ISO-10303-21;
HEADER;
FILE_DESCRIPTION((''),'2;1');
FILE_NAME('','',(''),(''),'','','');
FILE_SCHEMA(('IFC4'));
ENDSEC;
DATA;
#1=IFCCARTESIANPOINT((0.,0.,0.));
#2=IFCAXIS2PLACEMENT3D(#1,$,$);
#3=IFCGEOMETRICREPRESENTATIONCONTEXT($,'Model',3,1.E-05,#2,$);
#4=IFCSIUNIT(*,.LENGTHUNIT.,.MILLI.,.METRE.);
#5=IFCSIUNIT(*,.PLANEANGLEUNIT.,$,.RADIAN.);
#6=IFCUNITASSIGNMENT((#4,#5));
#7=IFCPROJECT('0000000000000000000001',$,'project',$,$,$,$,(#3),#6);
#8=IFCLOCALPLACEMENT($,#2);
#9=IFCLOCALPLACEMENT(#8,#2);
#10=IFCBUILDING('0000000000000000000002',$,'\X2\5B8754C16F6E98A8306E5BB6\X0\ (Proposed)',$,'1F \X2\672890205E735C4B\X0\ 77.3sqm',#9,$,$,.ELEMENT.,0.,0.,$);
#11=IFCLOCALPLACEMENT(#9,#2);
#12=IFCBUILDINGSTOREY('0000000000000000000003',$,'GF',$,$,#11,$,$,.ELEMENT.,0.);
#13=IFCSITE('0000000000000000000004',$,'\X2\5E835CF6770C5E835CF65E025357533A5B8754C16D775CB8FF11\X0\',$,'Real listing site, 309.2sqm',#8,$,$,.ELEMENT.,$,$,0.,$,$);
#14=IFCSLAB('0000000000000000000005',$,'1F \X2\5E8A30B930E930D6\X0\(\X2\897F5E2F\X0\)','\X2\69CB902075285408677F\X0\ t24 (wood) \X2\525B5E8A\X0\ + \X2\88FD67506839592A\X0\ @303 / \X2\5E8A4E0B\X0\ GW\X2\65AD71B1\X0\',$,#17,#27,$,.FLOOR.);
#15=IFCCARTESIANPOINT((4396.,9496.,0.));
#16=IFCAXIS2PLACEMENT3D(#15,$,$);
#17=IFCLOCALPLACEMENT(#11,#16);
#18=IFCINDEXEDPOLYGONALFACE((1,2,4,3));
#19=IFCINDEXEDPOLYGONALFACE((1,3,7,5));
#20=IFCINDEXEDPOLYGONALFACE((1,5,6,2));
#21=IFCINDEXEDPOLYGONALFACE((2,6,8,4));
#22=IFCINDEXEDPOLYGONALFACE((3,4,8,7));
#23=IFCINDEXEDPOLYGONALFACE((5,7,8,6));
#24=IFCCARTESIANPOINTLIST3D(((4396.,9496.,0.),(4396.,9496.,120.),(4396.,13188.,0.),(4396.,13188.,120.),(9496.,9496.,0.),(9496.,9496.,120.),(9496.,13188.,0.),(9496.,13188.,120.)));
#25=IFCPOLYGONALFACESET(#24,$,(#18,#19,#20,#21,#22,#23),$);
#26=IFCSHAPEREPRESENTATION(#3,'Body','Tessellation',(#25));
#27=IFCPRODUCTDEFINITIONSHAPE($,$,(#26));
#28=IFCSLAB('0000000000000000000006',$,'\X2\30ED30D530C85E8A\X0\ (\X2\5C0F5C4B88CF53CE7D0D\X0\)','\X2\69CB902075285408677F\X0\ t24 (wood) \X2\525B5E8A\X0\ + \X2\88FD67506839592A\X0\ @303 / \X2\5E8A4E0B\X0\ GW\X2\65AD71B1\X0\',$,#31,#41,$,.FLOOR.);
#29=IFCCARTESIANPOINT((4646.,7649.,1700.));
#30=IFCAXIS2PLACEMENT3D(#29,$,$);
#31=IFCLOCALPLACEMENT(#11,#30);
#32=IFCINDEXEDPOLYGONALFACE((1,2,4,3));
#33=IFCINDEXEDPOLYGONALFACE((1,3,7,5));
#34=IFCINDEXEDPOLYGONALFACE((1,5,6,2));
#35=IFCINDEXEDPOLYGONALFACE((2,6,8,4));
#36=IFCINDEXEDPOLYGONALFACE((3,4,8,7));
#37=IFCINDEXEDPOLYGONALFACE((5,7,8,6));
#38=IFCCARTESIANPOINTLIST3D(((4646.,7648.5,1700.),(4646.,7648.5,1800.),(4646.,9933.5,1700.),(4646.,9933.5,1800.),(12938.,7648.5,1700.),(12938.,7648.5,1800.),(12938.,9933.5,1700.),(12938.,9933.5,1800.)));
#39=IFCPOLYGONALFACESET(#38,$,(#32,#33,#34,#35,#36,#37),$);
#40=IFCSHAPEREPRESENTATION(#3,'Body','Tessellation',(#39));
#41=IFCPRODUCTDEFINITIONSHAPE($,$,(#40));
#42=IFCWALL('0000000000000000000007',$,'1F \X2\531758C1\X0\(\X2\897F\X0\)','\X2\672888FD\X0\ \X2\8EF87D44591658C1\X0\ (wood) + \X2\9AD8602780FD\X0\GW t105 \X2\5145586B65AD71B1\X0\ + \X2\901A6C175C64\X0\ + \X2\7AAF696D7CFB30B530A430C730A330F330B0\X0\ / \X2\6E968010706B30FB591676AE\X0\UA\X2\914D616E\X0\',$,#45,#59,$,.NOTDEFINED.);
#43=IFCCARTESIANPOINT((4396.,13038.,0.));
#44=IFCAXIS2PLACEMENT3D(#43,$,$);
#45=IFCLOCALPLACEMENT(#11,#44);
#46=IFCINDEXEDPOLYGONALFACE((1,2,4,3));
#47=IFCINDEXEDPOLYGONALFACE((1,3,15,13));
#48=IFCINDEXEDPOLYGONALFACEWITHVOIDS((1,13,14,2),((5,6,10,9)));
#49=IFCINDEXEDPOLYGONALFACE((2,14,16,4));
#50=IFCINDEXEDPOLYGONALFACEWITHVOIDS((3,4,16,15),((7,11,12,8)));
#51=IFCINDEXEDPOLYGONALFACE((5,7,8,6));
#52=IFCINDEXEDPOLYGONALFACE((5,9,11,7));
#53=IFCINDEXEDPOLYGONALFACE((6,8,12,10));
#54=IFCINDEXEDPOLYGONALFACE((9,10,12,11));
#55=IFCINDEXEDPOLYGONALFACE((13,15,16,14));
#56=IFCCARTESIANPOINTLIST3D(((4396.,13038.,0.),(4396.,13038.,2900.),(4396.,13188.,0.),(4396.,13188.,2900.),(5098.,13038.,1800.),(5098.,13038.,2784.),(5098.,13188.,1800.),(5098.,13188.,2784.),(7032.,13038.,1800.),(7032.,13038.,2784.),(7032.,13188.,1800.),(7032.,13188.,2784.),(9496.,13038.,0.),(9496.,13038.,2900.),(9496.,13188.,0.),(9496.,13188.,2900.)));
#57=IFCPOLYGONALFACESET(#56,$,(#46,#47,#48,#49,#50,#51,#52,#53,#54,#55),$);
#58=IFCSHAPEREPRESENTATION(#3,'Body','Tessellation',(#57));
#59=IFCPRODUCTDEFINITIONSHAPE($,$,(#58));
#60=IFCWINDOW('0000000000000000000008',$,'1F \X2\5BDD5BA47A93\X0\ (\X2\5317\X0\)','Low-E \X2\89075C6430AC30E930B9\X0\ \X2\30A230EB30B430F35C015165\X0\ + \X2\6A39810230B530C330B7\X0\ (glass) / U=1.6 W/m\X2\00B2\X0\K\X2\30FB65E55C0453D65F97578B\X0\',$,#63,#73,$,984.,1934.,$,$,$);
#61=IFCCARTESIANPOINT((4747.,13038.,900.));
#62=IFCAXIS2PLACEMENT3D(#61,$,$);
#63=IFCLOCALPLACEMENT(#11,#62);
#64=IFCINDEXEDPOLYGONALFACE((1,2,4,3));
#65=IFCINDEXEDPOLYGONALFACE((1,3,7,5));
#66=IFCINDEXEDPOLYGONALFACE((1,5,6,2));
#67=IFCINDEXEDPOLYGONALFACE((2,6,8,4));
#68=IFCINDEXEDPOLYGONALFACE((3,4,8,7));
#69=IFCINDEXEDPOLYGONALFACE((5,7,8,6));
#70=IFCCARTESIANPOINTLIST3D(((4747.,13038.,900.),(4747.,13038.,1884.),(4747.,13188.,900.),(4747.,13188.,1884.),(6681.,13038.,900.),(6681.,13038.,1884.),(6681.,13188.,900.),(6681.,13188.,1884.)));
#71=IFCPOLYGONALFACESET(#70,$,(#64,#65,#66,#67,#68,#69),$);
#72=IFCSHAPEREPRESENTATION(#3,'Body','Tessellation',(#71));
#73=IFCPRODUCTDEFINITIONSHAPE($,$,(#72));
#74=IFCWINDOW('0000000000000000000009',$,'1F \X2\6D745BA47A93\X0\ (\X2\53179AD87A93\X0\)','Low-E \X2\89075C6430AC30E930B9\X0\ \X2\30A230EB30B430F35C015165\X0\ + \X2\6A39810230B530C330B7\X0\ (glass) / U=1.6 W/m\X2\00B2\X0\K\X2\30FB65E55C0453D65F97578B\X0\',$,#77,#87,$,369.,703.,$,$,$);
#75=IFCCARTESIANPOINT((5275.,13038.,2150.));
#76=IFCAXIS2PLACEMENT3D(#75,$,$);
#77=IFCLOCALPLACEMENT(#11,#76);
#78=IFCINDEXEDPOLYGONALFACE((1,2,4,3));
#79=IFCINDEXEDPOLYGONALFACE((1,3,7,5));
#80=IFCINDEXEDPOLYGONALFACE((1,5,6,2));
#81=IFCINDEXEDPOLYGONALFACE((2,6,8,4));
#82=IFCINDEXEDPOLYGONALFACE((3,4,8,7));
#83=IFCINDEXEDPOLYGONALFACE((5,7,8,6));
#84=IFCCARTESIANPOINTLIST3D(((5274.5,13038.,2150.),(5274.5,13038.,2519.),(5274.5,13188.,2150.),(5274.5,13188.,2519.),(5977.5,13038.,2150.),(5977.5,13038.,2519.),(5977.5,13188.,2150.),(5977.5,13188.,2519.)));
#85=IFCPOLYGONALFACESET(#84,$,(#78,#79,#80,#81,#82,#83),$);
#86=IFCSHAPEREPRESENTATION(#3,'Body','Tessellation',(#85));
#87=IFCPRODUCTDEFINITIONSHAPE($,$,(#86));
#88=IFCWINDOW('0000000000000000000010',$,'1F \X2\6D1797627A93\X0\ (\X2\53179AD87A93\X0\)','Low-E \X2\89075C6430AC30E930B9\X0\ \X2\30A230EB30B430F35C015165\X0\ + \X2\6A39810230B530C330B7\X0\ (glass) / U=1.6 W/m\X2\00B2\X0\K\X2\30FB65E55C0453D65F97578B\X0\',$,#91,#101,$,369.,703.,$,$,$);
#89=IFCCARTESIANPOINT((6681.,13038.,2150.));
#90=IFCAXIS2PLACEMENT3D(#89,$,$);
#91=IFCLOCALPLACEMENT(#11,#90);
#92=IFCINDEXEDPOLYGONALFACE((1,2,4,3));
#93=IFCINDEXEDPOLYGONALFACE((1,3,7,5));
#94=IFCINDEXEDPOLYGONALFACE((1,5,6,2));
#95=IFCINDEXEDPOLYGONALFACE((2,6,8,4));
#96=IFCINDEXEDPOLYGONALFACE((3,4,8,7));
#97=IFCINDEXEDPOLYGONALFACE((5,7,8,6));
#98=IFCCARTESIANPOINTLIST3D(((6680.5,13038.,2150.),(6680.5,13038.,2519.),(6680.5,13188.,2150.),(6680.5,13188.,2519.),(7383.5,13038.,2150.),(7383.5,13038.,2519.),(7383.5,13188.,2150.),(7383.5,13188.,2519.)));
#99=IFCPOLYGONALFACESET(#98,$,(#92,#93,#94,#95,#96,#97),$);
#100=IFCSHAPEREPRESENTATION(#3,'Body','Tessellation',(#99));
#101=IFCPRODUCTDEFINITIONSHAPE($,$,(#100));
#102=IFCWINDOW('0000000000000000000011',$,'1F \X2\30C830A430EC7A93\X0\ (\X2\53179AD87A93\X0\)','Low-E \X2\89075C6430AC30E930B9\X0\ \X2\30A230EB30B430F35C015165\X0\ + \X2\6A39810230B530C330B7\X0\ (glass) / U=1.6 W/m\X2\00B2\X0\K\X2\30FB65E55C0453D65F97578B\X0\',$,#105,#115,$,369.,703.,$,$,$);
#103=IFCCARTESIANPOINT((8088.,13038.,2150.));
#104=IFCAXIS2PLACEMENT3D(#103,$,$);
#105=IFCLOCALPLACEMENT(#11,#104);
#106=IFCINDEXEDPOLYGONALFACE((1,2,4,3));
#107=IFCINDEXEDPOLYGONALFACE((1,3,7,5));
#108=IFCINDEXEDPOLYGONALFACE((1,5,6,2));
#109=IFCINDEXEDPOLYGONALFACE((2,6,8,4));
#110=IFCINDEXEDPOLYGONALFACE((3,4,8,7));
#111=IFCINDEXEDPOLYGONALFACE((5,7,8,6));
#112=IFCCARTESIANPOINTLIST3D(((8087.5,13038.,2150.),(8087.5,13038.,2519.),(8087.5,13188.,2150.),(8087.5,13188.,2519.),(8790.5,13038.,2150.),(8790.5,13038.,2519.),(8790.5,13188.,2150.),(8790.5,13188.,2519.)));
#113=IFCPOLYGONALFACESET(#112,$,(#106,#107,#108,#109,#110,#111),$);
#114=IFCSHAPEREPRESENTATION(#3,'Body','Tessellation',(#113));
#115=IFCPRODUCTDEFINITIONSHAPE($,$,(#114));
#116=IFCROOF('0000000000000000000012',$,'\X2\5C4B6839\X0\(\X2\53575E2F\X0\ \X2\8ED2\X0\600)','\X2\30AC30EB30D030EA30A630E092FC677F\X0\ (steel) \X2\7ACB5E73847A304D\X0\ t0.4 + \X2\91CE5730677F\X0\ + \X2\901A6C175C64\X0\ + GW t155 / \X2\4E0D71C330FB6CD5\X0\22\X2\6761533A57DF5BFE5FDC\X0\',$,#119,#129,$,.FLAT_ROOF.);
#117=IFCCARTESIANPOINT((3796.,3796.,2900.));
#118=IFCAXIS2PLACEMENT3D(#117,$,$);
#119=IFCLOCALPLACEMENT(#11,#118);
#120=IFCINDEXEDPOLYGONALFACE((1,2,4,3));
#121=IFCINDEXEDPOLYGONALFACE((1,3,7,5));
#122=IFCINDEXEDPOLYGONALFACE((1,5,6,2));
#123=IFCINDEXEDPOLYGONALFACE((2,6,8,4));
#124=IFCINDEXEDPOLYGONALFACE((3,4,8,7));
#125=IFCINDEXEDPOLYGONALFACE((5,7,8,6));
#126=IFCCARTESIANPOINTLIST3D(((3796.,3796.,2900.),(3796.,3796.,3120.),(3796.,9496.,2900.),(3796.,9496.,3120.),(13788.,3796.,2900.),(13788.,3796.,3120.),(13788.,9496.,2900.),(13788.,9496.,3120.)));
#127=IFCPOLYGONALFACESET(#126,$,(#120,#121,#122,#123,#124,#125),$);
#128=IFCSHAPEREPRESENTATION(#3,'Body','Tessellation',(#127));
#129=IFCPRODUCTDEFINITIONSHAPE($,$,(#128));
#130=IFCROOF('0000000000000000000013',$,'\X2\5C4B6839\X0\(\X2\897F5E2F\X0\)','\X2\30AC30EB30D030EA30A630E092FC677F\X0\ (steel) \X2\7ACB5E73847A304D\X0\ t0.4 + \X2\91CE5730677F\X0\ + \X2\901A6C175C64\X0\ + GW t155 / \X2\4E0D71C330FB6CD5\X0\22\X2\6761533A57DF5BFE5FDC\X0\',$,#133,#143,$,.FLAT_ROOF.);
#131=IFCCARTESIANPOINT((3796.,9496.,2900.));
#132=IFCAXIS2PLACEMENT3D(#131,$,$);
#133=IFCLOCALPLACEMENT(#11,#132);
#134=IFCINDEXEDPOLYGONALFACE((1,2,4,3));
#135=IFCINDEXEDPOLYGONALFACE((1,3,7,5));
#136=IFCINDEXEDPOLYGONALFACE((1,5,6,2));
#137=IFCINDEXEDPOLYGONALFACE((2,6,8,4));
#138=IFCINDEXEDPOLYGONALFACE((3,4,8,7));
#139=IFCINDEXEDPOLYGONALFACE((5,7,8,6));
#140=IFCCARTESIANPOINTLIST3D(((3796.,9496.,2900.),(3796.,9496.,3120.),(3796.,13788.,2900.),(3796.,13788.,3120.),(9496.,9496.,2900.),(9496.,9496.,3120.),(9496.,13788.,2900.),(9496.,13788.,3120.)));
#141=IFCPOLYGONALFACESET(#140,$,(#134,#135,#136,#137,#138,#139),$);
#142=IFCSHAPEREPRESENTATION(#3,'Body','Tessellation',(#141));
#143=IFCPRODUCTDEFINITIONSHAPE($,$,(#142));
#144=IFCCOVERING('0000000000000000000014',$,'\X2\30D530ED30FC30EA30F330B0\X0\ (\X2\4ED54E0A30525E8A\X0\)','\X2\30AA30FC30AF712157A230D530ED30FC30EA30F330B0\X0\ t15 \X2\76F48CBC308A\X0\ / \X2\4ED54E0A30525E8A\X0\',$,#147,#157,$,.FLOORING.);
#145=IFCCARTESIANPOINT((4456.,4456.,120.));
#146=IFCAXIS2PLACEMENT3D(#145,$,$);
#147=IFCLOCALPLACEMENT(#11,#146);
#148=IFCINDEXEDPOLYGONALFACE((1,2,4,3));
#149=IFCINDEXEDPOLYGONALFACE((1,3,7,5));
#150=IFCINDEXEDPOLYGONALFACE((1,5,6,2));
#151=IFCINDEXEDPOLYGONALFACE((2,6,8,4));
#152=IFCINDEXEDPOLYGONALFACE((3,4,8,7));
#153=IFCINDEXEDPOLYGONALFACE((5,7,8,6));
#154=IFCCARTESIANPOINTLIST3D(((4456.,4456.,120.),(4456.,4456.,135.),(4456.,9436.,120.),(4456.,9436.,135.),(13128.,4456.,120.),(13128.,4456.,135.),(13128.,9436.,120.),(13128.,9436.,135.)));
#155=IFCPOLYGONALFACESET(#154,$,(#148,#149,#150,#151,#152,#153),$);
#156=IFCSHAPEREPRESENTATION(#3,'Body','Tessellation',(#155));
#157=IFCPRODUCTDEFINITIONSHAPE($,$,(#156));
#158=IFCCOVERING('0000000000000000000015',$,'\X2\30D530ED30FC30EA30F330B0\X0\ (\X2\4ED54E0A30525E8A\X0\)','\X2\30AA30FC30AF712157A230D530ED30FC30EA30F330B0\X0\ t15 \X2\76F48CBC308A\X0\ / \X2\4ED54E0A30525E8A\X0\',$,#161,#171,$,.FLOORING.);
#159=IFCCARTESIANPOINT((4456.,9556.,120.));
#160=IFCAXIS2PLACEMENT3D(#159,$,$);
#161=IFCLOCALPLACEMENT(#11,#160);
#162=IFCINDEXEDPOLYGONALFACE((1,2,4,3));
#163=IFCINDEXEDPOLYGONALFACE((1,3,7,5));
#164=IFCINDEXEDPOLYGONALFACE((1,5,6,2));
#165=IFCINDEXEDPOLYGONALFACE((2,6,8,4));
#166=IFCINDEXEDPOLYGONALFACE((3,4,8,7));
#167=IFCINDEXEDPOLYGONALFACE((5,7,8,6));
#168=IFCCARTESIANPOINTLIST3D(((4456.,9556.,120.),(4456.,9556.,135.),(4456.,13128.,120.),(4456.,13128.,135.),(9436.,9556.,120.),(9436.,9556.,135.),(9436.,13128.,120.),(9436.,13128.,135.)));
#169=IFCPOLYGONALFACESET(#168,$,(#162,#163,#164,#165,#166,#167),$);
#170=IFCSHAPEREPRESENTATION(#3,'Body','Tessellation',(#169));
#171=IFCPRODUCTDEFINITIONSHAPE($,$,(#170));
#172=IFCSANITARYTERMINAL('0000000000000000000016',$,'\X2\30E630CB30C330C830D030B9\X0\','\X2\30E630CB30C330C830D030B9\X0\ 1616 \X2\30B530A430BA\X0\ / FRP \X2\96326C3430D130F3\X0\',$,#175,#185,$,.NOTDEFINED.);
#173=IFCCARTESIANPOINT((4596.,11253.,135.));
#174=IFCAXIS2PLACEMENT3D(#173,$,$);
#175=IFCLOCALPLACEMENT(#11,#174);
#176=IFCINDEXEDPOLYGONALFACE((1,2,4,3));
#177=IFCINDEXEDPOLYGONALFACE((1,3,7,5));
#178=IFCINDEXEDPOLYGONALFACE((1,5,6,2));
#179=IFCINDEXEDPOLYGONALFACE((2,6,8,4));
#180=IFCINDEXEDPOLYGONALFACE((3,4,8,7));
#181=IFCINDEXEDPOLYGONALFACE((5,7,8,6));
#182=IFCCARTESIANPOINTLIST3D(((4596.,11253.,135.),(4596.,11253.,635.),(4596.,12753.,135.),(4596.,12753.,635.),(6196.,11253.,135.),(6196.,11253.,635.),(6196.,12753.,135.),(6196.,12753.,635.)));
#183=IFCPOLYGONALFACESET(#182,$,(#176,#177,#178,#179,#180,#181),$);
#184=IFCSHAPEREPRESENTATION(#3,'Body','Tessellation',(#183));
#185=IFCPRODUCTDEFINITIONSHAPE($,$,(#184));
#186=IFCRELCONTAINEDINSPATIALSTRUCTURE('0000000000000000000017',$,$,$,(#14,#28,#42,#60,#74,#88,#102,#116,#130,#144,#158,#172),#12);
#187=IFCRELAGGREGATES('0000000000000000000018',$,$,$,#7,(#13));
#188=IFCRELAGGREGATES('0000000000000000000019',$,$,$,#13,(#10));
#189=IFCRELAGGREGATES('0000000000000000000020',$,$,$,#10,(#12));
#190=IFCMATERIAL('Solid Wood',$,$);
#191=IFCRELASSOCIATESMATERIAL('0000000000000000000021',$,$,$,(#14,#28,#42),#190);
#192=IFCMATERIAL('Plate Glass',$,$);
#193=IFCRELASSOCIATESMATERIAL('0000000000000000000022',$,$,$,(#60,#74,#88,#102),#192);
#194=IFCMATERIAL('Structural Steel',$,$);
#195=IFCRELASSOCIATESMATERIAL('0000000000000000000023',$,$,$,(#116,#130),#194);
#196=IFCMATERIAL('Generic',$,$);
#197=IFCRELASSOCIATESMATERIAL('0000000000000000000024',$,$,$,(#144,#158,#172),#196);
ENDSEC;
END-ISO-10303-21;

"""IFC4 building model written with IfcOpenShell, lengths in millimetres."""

from ifc_helpers import new_model, si_unit, frame, frame_2d, origin, place, context, project, spatial, rectangle, extrude, material, element, fill, save


model = new_model("IFC4")

# Units and contexts
model_context = context("Model", 3, precision=1e-05, world=origin())
ifc_project = project(units=[si_unit("LENGTHUNIT", "METRE", prefix="MILLI"), si_unit("PLANEANGLEUNIT", "RADIAN")], contexts=[model_context])

# Site, building, storey
site_placement = place(None, origin())
site = spatial("IfcSite", under=ifc_project, at=site_placement, Name="広島県広島市南区宇品海岸１", ObjectType="Real listing site, 309.2sqm", CompositionType="ELEMENT", RefElevation=0.0)
building_placement = place(site_placement, origin())
building = spatial("IfcBuilding", under=site, at=building_placement, Name="宇品潮風の家 (Proposed)", ObjectType="1F 木造平屋 77.3sqm", CompositionType="ELEMENT", ElevationOfRefHeight=0.0, ElevationOfTerrain=0.0)
storey_placement = place(building_placement, origin())
storey = spatial("IfcBuildingStorey", under=building, at=storey_placement, Name="GF", CompositionType="ELEMENT", Elevation=0.0)

# Slabs
ifc_material_1 = material(Name="Solid Wood")
slab_1_placement = place(storey_placement, frame((4396.0, 9496.0, 0.0)))
element("IfcSlab", 1, at=slab_1_placement, inside=storey, material=ifc_material_1, Name="1F 床スラブ(西帯)", Description="構造用合板 t24 (wood) 剛床 + 製材根太 @303 / 床下 GW断熱", PredefinedType="FLOOR", context=model_context, shape_type="SweptSolid", body=[
    extrude(rectangle(XDim=5100.0, YDim=3692.0, at=frame_2d((2550.0, 1846.0))), frame((4396.0, 9496.0, 0.0)), (0.0, 0.0, 1.0), 120.0),
])
slab_2_placement = place(storey_placement, frame((4646.0, 7649.0, 1700.0)))
element("IfcSlab", 2, at=slab_2_placement, inside=storey, material=ifc_material_1, Name="ロフト床 (小屋裏収納)", Description="構造用合板 t24 (wood) 剛床 + 製材根太 @303 / 床下 GW断熱", PredefinedType="FLOOR", context=model_context, shape_type="SweptSolid", body=[
    extrude(rectangle(XDim=8292.0, YDim=2285.0, at=frame_2d((4146.0, 1142.0))), frame((4646.0, 7649.0, 1700.0)), (0.0, 0.0, 1.0), 100.0),
])

# Shared definitions
ifc_material_2 = material(Name="Plate Glass")

# Wall, openings, windows
wall_1_placement = place(storey_placement, frame((4396.0, 13038.0, 0.0)))
wall_1 = element("IfcWall", 3, at=wall_1_placement, inside=storey, material=ifc_material_1, Name="1F 北壁(西)", Description="木製 軸組外壁 (wood) + 高性能GW t105 充填断熱 + 通気層 + 窯業系サイディング / 準耐火・外皮UA配慮", PredefinedType="NOTDEFINED", context=model_context, shape_type="SweptSolid", body=[
    extrude(rectangle(XDim=5100.0, YDim=150.0, at=frame_2d((2550.0, 75.0))), frame((4396.0, 13038.0, 0.0)), (0.0, 0.0, 1.0), 2900.0),
])
opening_1_placement = place(storey_placement, frame((4747.0, 13038.0, 900.0)))
opening_1 = element("IfcOpeningElement", 4, at=opening_1_placement, cuts=wall_1, PredefinedType="NOTDEFINED", context=model_context, shape_type="SweptSolid", body=[
    extrude(rectangle(XDim=1934.0, YDim=150.0, at=frame_2d((967.0, 75.0))), frame((4747.0, 13038.0, 900.0)), (0.0, 0.0, 1.0), 984.0),
])
opening_2_placement = place(storey_placement, frame((5275.0, 13038.0, 2150.0)))
opening_2 = element("IfcOpeningElement", 5, at=opening_2_placement, cuts=wall_1, PredefinedType="NOTDEFINED", context=model_context, shape_type="SweptSolid", body=[
    extrude(rectangle(XDim=703.0, YDim=150.0, at=frame_2d((351.0, 75.0))), frame((5275.0, 13038.0, 2150.0)), (0.0, 0.0, 1.0), 369.0),
])
opening_3_placement = place(storey_placement, frame((6681.0, 13038.0, 2150.0)))
opening_3 = element("IfcOpeningElement", 6, at=opening_3_placement, cuts=wall_1, PredefinedType="NOTDEFINED", context=model_context, shape_type="SweptSolid", body=[
    extrude(rectangle(XDim=703.0, YDim=150.0, at=frame_2d((351.0, 75.0))), frame((6681.0, 13038.0, 2150.0)), (0.0, 0.0, 1.0), 369.0),
])
opening_4_placement = place(storey_placement, frame((8088.0, 13038.0, 2150.0)))
opening_4 = element("IfcOpeningElement", 7, at=opening_4_placement, cuts=wall_1, PredefinedType="NOTDEFINED", context=model_context, shape_type="SweptSolid", body=[
    extrude(rectangle(XDim=703.0, YDim=150.0, at=frame_2d((351.0, 75.0))), frame((8088.0, 13038.0, 2150.0)), (0.0, 0.0, 1.0), 369.0),
])
window_1_placement = place(storey_placement, frame((4747.0, 13038.0, 900.0)))
window_1 = element("IfcWindow", 8, at=window_1_placement, inside=storey, material=ifc_material_2, Name="1F 寝室窓 (北)", Description="Low-E 複層ガラス アルゴン封入 + 樹脂サッシ (glass) / U=1.6 W/m²K・日射取得型", OverallHeight=984.0, OverallWidth=1934.0, context=model_context, shape_type="SweptSolid", body=[
    extrude(rectangle(XDim=1934.0, YDim=150.0, at=frame_2d((967.0, 75.0))), frame((4747.0, 13038.0, 900.0)), (0.0, 0.0, 1.0), 984.0),
])
fill(opening_1, window_1)
window_2_placement = place(storey_placement, frame((5275.0, 13038.0, 2150.0)))
window_2 = element("IfcWindow", 9, at=window_2_placement, inside=storey, material=ifc_material_2, Name="1F 浴室窓 (北高窓)", Description="Low-E 複層ガラス アルゴン封入 + 樹脂サッシ (glass) / U=1.6 W/m²K・日射取得型", OverallHeight=369.0, OverallWidth=703.0, context=model_context, shape_type="SweptSolid", body=[
    extrude(rectangle(XDim=703.0, YDim=150.0, at=frame_2d((351.0, 75.0))), frame((5275.0, 13038.0, 2150.0)), (0.0, 0.0, 1.0), 369.0),
])
fill(opening_2, window_2)
window_3_placement = place(storey_placement, frame((6681.0, 13038.0, 2150.0)))
window_3 = element("IfcWindow", 10, at=window_3_placement, inside=storey, material=ifc_material_2, Name="1F 洗面窓 (北高窓)", Description="Low-E 複層ガラス アルゴン封入 + 樹脂サッシ (glass) / U=1.6 W/m²K・日射取得型", OverallHeight=369.0, OverallWidth=703.0, context=model_context, shape_type="SweptSolid", body=[
    extrude(rectangle(XDim=703.0, YDim=150.0, at=frame_2d((351.0, 75.0))), frame((6681.0, 13038.0, 2150.0)), (0.0, 0.0, 1.0), 369.0),
])
fill(opening_3, window_3)
window_4_placement = place(storey_placement, frame((8088.0, 13038.0, 2150.0)))
window_4 = element("IfcWindow", 11, at=window_4_placement, inside=storey, material=ifc_material_2, Name="1F トイレ窓 (北高窓)", Description="Low-E 複層ガラス アルゴン封入 + 樹脂サッシ (glass) / U=1.6 W/m²K・日射取得型", OverallHeight=369.0, OverallWidth=703.0, context=model_context, shape_type="SweptSolid", body=[
    extrude(rectangle(XDim=703.0, YDim=150.0, at=frame_2d((351.0, 75.0))), frame((8088.0, 13038.0, 2150.0)), (0.0, 0.0, 1.0), 369.0),
])
fill(opening_4, window_4)

# Roofs
ifc_material_3 = material(Name="Structural Steel")
roof_1_placement = place(storey_placement, frame((3796.0, 3796.0, 2900.0)))
element("IfcRoof", 12, at=roof_1_placement, inside=storey, material=ifc_material_3, Name="屋根(南帯 軒600)", Description="ガルバリウム鋼板 (steel) 立平葺き t0.4 + 野地板 + 通気層 + GW t155 / 不燃・法22条区域対応", PredefinedType="FLAT_ROOF", context=model_context, shape_type="SweptSolid", body=[
    extrude(rectangle(XDim=9992.0, YDim=5700.0, at=frame_2d((4996.0, 2850.0))), frame((3796.0, 3796.0, 2900.0)), (0.0, 0.0, 1.0), 220.0),
])
roof_2_placement = place(storey_placement, frame((3796.0, 9496.0, 2900.0)))
element("IfcRoof", 13, at=roof_2_placement, inside=storey, material=ifc_material_3, Name="屋根(西帯)", Description="ガルバリウム鋼板 (steel) 立平葺き t0.4 + 野地板 + 通気層 + GW t155 / 不燃・法22条区域対応", PredefinedType="FLAT_ROOF", context=model_context, shape_type="SweptSolid", body=[
    extrude(rectangle(XDim=5700.0, YDim=4292.0, at=frame_2d((2850.0, 2146.0))), frame((3796.0, 9496.0, 2900.0)), (0.0, 0.0, 1.0), 220.0),
])

# Coverings
ifc_material_4 = material(Name="Generic")
covering_1_placement = place(storey_placement, frame((4456.0, 4456.0, 120.0)))
element("IfcCovering", 14, at=covering_1_placement, inside=storey, material=ifc_material_4, Name="フローリング (仕上げ床)", Description="オーク無垢フローリング t15 直貼り / 仕上げ床", PredefinedType="FLOORING", context=model_context, shape_type="SweptSolid", body=[
    extrude(rectangle(XDim=8672.0, YDim=4980.0, at=frame_2d((4336.0, 2490.0))), frame((4456.0, 4456.0, 120.0)), (0.0, 0.0, 1.0), 15.0),
])
covering_2_placement = place(storey_placement, frame((4456.0, 9556.0, 120.0)))
element("IfcCovering", 15, at=covering_2_placement, inside=storey, material=ifc_material_4, Name="フローリング (仕上げ床)", Description="オーク無垢フローリング t15 直貼り / 仕上げ床", PredefinedType="FLOORING", context=model_context, shape_type="SweptSolid", body=[
    extrude(rectangle(XDim=4980.0, YDim=3572.0, at=frame_2d((2490.0, 1786.0))), frame((4456.0, 9556.0, 120.0)), (0.0, 0.0, 1.0), 15.0),
])

# Sanitary terminal
sanitary_terminal_placement = place(storey_placement, frame((4596.0, 11253.0, 135.0)))
element("IfcSanitaryTerminal", 16, at=sanitary_terminal_placement, inside=storey, material=ifc_material_4, Name="ユニットバス", Description="ユニットバス 1616 サイズ / FRP 防水パン", PredefinedType="NOTDEFINED", context=model_context, shape_type="SweptSolid", body=[
    extrude(rectangle(XDim=1600.0, YDim=1500.0, at=frame_2d((800.0, 750.0))), frame((4596.0, 11253.0, 135.0)), (0.0, 0.0, 1.0), 500.0),
])

save(model, "model.ifc")
